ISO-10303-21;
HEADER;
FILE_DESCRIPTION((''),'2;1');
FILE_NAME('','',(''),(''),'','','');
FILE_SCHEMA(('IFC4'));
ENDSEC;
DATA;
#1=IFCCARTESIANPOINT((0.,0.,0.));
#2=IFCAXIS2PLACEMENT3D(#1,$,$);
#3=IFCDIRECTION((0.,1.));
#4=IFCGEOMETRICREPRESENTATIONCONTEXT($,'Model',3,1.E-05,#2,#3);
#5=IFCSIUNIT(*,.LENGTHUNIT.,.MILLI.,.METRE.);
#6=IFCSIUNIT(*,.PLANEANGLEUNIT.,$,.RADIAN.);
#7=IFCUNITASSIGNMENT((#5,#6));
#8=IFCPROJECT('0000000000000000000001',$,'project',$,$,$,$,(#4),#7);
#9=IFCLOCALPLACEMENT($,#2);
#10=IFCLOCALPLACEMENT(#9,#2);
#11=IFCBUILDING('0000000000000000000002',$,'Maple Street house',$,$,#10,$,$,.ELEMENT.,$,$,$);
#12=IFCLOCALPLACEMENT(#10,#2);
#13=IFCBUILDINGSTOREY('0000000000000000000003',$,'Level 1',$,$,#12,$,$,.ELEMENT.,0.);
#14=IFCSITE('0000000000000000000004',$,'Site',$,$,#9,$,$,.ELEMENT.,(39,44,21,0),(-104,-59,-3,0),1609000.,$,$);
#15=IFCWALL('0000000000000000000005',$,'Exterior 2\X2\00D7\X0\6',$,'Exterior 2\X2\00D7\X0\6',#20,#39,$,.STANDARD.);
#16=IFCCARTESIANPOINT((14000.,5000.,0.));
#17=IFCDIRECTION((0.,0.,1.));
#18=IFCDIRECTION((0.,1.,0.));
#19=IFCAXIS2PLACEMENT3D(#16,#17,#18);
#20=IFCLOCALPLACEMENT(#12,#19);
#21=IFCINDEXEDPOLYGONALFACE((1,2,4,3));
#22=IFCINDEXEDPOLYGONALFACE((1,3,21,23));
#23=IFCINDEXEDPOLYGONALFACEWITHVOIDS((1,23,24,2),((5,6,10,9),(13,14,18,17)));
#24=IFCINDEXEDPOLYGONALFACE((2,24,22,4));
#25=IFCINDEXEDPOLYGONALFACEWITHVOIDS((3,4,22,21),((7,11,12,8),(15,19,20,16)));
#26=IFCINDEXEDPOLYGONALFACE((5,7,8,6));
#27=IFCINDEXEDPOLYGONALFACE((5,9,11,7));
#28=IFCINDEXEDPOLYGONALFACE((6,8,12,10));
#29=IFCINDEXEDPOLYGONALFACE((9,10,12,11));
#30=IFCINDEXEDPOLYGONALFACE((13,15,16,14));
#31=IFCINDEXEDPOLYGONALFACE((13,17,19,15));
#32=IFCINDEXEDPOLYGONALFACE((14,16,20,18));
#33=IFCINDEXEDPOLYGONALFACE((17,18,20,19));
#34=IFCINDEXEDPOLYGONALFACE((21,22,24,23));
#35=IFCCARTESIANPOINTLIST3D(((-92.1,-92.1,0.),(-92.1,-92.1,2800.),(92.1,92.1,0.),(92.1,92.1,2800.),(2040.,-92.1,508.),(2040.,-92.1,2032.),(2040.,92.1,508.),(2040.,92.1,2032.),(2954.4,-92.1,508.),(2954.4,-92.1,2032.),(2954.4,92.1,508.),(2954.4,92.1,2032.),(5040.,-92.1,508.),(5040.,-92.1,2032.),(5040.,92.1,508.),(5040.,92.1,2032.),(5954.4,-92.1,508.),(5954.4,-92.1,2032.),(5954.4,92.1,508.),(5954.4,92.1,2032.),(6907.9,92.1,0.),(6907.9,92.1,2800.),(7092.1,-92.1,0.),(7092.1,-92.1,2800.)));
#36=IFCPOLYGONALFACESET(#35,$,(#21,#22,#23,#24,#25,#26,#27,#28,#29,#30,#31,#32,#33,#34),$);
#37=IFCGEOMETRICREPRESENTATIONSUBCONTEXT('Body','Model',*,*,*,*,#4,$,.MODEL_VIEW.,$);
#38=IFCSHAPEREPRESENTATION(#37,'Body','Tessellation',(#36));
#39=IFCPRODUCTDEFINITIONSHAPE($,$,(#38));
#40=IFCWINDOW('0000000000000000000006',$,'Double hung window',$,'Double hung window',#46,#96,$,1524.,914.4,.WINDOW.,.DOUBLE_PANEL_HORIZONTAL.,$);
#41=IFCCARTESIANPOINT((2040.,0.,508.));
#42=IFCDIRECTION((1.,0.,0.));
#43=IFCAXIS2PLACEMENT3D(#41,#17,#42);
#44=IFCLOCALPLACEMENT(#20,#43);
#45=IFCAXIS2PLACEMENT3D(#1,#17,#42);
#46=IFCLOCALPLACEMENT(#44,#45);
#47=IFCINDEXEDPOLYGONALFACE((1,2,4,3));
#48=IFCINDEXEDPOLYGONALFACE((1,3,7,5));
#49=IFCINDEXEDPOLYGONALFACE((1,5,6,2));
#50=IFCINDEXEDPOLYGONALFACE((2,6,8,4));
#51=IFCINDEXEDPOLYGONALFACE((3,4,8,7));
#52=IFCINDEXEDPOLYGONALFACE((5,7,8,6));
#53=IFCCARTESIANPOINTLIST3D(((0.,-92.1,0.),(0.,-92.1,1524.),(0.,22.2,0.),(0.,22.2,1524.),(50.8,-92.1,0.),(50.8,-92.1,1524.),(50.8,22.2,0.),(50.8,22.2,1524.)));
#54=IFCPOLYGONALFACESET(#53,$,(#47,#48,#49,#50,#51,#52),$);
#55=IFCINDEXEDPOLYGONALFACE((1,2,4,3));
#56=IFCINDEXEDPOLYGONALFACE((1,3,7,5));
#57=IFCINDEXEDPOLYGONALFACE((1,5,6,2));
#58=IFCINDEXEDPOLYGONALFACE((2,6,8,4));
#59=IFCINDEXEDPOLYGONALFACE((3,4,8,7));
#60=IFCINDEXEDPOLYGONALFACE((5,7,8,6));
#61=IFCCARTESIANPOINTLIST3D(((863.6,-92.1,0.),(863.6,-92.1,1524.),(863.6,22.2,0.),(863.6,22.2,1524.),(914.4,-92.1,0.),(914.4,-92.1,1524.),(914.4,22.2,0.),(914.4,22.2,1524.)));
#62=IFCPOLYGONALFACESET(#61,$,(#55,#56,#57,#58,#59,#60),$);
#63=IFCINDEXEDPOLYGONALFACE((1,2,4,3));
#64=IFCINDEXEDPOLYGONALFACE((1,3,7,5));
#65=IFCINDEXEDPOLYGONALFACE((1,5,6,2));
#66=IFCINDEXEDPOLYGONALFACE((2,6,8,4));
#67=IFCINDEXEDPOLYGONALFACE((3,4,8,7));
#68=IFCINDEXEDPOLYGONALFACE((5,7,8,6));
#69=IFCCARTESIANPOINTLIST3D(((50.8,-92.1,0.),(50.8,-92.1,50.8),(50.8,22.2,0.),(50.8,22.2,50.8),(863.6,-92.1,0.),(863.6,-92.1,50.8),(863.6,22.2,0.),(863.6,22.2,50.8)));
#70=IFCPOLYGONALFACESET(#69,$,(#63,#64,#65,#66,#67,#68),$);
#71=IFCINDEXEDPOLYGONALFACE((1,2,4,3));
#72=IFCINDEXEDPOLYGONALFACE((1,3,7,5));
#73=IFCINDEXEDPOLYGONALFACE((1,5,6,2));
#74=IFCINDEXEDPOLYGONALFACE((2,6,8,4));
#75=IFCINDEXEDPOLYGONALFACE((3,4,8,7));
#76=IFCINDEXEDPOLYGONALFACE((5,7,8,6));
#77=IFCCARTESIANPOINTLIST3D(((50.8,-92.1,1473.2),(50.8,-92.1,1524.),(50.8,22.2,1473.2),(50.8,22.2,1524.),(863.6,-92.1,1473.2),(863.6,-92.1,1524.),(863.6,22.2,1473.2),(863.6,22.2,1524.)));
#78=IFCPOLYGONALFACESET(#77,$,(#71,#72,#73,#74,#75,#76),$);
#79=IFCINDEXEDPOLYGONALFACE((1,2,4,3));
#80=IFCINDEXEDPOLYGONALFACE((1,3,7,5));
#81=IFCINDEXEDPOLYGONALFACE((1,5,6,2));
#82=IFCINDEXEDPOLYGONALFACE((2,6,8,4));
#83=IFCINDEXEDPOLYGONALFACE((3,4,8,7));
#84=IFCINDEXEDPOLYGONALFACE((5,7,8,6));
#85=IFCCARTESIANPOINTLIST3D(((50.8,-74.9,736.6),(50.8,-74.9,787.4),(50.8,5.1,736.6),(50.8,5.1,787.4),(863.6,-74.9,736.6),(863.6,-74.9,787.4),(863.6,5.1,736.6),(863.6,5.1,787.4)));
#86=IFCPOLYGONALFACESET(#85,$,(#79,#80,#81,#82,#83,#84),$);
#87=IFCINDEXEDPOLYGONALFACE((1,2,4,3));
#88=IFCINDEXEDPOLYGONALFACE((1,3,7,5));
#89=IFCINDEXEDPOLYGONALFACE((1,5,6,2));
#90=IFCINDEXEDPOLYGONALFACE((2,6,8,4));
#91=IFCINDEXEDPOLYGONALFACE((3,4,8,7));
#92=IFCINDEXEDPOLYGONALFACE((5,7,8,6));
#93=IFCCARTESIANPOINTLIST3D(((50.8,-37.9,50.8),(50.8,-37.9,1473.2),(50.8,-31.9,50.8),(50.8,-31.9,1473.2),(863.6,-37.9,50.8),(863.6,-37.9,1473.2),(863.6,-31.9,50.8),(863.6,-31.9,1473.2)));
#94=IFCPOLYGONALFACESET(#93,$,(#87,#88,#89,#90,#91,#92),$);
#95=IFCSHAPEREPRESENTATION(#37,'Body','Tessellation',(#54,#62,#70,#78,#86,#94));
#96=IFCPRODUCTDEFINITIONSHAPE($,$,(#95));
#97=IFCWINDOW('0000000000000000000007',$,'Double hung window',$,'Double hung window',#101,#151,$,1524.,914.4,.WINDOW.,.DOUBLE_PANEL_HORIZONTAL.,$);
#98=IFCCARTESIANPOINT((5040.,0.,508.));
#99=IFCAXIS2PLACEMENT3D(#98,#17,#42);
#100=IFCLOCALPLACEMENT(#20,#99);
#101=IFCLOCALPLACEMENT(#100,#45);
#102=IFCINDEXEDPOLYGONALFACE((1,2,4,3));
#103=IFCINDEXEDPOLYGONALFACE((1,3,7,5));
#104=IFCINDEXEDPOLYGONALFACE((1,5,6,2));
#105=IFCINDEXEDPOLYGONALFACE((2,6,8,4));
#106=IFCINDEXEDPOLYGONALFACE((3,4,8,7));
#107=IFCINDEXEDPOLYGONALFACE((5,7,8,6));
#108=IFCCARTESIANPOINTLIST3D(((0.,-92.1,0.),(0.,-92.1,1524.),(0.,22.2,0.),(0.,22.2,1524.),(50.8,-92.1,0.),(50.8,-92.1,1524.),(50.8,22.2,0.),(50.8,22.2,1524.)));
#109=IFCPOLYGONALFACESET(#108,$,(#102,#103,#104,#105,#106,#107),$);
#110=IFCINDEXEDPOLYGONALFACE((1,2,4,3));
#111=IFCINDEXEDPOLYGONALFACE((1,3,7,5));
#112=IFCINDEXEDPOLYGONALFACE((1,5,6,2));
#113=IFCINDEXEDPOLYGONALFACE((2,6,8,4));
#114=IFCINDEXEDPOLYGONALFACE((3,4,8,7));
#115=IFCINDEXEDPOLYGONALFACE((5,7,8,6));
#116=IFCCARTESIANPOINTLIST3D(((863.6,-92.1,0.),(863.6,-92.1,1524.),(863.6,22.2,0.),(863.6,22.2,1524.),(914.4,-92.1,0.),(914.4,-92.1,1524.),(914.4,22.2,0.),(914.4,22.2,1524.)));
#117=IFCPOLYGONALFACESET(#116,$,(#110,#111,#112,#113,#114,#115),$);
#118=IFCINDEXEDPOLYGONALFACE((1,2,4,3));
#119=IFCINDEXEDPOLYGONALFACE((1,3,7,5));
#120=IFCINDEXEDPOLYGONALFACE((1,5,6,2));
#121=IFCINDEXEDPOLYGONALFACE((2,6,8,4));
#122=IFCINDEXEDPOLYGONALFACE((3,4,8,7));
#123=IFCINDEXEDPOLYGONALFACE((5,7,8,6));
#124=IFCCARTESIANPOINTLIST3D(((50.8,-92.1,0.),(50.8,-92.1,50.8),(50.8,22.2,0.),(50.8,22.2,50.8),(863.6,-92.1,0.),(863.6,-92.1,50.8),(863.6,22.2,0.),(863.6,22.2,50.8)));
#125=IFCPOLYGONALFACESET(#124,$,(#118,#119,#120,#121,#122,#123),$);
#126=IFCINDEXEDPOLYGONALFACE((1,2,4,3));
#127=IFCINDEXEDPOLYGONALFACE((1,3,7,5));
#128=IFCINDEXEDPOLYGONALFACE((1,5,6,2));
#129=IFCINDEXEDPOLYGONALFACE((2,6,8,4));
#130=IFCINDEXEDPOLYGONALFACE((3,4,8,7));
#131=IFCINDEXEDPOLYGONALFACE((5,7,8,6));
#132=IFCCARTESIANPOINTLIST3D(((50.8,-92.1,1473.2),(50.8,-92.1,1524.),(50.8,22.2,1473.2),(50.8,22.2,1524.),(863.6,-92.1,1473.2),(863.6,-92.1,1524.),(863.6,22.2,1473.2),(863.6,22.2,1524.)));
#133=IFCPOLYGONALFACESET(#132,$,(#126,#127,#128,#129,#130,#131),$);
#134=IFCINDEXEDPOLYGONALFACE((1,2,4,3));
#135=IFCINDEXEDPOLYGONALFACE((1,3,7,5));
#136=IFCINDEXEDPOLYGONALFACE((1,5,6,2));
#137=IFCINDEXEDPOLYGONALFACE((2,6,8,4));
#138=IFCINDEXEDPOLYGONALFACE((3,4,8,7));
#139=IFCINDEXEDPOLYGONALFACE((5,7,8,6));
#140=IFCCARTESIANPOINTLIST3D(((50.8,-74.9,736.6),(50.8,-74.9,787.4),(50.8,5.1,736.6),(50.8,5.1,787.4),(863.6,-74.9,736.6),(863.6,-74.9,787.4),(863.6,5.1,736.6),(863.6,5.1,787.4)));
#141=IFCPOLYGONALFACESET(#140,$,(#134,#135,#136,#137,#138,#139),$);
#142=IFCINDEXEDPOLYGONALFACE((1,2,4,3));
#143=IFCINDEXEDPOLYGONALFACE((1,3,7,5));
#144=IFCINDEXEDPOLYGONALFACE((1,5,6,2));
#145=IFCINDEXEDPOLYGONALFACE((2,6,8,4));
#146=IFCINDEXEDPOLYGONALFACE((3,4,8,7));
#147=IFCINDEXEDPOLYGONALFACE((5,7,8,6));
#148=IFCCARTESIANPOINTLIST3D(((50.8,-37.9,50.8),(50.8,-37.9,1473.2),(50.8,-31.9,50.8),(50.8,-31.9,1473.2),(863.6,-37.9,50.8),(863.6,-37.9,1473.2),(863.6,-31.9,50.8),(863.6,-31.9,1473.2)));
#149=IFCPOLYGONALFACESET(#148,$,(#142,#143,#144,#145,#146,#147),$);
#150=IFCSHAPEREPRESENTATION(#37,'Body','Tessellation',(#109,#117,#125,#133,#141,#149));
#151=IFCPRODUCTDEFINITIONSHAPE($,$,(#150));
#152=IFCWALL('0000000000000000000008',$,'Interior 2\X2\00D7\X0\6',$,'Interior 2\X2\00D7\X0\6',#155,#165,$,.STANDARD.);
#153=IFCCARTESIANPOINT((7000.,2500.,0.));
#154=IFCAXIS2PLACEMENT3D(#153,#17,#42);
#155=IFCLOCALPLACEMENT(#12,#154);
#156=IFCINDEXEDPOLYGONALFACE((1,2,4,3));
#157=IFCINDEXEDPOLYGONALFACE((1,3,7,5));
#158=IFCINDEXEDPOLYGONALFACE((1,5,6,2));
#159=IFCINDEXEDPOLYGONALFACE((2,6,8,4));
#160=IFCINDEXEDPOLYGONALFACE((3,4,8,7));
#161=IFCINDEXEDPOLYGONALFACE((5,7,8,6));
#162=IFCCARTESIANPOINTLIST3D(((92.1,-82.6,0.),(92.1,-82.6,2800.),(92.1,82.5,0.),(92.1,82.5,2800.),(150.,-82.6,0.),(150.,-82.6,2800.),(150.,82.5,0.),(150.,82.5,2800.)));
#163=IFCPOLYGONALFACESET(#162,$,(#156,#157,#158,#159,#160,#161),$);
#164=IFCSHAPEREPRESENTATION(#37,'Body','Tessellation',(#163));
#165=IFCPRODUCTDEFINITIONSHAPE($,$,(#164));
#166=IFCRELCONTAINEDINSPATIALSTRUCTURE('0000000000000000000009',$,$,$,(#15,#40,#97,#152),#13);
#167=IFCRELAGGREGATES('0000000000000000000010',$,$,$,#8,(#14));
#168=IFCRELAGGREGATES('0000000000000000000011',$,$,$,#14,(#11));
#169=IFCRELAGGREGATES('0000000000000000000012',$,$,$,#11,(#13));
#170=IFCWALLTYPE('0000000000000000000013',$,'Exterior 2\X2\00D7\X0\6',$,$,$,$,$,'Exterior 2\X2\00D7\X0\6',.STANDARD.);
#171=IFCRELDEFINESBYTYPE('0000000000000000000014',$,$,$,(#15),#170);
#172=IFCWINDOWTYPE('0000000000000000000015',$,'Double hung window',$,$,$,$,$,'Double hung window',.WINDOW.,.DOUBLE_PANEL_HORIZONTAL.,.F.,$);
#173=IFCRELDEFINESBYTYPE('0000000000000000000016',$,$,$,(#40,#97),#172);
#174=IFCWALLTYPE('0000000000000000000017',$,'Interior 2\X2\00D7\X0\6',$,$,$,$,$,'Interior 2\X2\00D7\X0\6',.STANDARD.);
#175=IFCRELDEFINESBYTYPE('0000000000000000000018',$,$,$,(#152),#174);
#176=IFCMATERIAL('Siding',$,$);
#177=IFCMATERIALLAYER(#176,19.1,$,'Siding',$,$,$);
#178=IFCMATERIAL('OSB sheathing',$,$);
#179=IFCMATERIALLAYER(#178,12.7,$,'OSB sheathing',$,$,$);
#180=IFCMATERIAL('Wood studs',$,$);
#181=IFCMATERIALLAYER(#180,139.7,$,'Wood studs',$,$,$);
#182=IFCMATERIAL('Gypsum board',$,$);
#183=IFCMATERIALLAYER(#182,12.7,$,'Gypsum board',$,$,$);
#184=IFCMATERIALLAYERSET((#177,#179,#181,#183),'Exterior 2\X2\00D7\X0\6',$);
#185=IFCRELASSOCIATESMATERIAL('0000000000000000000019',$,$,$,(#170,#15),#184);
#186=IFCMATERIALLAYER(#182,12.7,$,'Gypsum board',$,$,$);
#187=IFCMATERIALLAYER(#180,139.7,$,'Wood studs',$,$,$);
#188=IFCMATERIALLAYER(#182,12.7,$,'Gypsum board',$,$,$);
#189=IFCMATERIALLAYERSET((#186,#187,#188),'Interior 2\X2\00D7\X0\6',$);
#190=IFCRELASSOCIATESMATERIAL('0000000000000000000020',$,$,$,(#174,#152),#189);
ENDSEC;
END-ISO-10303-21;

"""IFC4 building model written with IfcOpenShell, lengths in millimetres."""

from ifc_helpers import new_model, si_unit, direction, frame, origin, origin_with_axes, place, context, subcontext, project, spatial, polyline, outline, extrude, material, layer, layer_set, layer_usage, type_object, element, fill, save


model = new_model("IFC4")

# Units and contexts
model_context = context("Model", 3, precision=1e-05, world=origin(), true_north=direction((0.0, 1.0)))
body_context = subcontext(model_context, "Body", "Model", "MODEL_VIEW")
ifc_project = project(units=[si_unit("LENGTHUNIT", "METRE", prefix="MILLI"), si_unit("PLANEANGLEUNIT", "RADIAN")], contexts=[model_context])

# Site, building, storey
site_placement = place(None, origin())
site = spatial("IfcSite", under=ifc_project, at=site_placement, Name="Site", CompositionType="ELEMENT", RefLatitude=(39, 44, 21, 0), RefLongitude=(-104, -59, -3, 0), RefElevation=1609000.0)
building_placement = place(site_placement, origin())
building = spatial("IfcBuilding", under=site, at=building_placement, Name="Maple Street house", CompositionType="ELEMENT")
storey_placement = place(building_placement, origin())
storey = spatial("IfcBuildingStorey", under=building, at=storey_placement, Name="Level 1", CompositionType="ELEMENT", Elevation=0.0)

# Shared definitions
ifc_material_1 = material(Name="Siding")
ifc_layer_1 = layer(ifc_material_1, 19.1, Name="Siding")
ifc_material_2 = material(Name="OSB sheathing")
ifc_layer_2 = layer(ifc_material_2, 12.7, Name="OSB sheathing")
ifc_material_3 = material(Name="Wood studs")
ifc_layer_3 = layer(ifc_material_3, 139.7, Name="Wood studs")
ifc_material_4 = material(Name="Gypsum board")
ifc_layer_4 = layer(ifc_material_4, 12.7, Name="Gypsum board")
ifc_layer_set_1 = layer_set([ifc_layer_1, ifc_layer_2, ifc_layer_3, ifc_layer_4], Name="Exterior 2×6")
wall_type_1 = type_object("IfcWallType", Name="Exterior 2×6", ElementType="Exterior 2×6", PredefinedType="STANDARD", material=ifc_layer_set_1)

# Wall, openings, windows
ifc_layer_usage_1 = layer_usage(ifc_layer_set_1, "AXIS2", "POSITIVE", -92.1)
wall_1_placement = place(storey_placement, frame((14000.0, 5000.0, 0.0), z_axis=(0.0, 0.0, 1.0), x_axis=(0.0, 1.0, 0.0)))
wall_1 = element("IfcWall", 1, at=wall_1_placement, inside=storey, type_object=wall_type_1, material=ifc_layer_usage_1, Name="Exterior 2×6", ObjectType="Exterior 2×6", PredefinedType="STANDARD", context=body_context, shape_type="SweptSolid", body=[
    extrude(outline(polyline([(-92.1, -92.1), (7092.1, -92.1), (6907.9, 92.1), (92.1, 92.1), (-92.1, -92.1)])), origin(), (0.0, 0.0, 1.0), 2800.0),
])
opening_1_placement = place(wall_1_placement, frame((2040.0, 0.0, 508.0), z_axis=(0.0, 0.0, 1.0), x_axis=(1.0, 0.0, 0.0)))
opening_1 = element("IfcOpeningElement", 2, at=opening_1_placement, cuts=wall_1, PredefinedType="OPENING", context=body_context, shape_type="SweptSolid", body=[
    extrude(outline(polyline([(0.0, -102.1), (914.4, -102.1), (914.4, 102.1), (0.0, 102.1), (0.0, -102.1)])), origin(), (0.0, 0.0, 1.0), 1524.0),
])
opening_2_placement = place(wall_1_placement, frame((5040.0, 0.0, 508.0), z_axis=(0.0, 0.0, 1.0), x_axis=(1.0, 0.0, 0.0)))
opening_2 = element("IfcOpeningElement", 3, at=opening_2_placement, cuts=wall_1, PredefinedType="OPENING", context=body_context, shape_type="SweptSolid", body=[
    extrude(outline(polyline([(0.0, -102.1), (914.4, -102.1), (914.4, 102.1), (0.0, 102.1), (0.0, -102.1)])), origin(), (0.0, 0.0, 1.0), 1524.0),
])
window_type_1 = type_object("IfcWindowType", Name="Double hung window", ElementType="Double hung window", ParameterTakesPrecedence=False, PartitioningType="DOUBLE_PANEL_HORIZONTAL", PredefinedType="WINDOW")
window_1_placement = place(opening_1_placement, origin_with_axes())
window_1 = element("IfcWindow", 4, at=window_1_placement, inside=storey, type_object=window_type_1, Name="Double hung window", ObjectType="Double hung window", OverallHeight=1524.0, OverallWidth=914.4, PartitioningType="DOUBLE_PANEL_HORIZONTAL", PredefinedType="WINDOW", context=body_context, shape_type="SweptSolid", body=[
    extrude(outline(polyline([(0.0, -92.1), (50.8, -92.1), (50.8, 22.2), (0.0, 22.2), (0.0, -92.1)])), origin(), (0.0, 0.0, 1.0), 1524.0),
    extrude(outline(polyline([(863.6, -92.1), (914.4, -92.1), (914.4, 22.2), (863.6, 22.2), (863.6, -92.1)])), origin(), (0.0, 0.0, 1.0), 1524.0),
    extrude(outline(polyline([(50.8, -92.1), (863.6, -92.1), (863.6, 22.2), (50.8, 22.2), (50.8, -92.1)])), origin(), (0.0, 0.0, 1.0), 50.8),
    extrude(outline(polyline([(50.8, -92.1), (863.6, -92.1), (863.6, 22.2), (50.8, 22.2), (50.8, -92.1)])), frame((0.0, 0.0, 1473.2)), (0.0, 0.0, 1.0), 50.8),
    extrude(outline(polyline([(50.8, -74.9), (863.6, -74.9), (863.6, 5.1), (50.8, 5.1), (50.8, -74.9)])), frame((0.0, 0.0, 736.6)), (0.0, 0.0, 1.0), 50.8),
    extrude(outline(polyline([(50.8, -37.9), (863.6, -37.9), (863.6, -31.9), (50.8, -31.9), (50.8, -37.9)])), frame((0.0, 0.0, 50.8)), (0.0, 0.0, 1.0), 1422.4),
])
fill(opening_1, window_1)
window_2_placement = place(opening_2_placement, origin_with_axes())
window_2 = element("IfcWindow", 5, at=window_2_placement, inside=storey, type_object=window_type_1, Name="Double hung window", ObjectType="Double hung window", OverallHeight=1524.0, OverallWidth=914.4, PartitioningType="DOUBLE_PANEL_HORIZONTAL", PredefinedType="WINDOW", context=body_context, shape_type="SweptSolid", body=[
    extrude(outline(polyline([(0.0, -92.1), (50.8, -92.1), (50.8, 22.2), (0.0, 22.2), (0.0, -92.1)])), origin(), (0.0, 0.0, 1.0), 1524.0),
    extrude(outline(polyline([(863.6, -92.1), (914.4, -92.1), (914.4, 22.2), (863.6, 22.2), (863.6, -92.1)])), origin(), (0.0, 0.0, 1.0), 1524.0),
    extrude(outline(polyline([(50.8, -92.1), (863.6, -92.1), (863.6, 22.2), (50.8, 22.2), (50.8, -92.1)])), origin(), (0.0, 0.0, 1.0), 50.8),
    extrude(outline(polyline([(50.8, -92.1), (863.6, -92.1), (863.6, 22.2), (50.8, 22.2), (50.8, -92.1)])), frame((0.0, 0.0, 1473.2)), (0.0, 0.0, 1.0), 50.8),
    extrude(outline(polyline([(50.8, -74.9), (863.6, -74.9), (863.6, 5.1), (50.8, 5.1), (50.8, -74.9)])), frame((0.0, 0.0, 736.6)), (0.0, 0.0, 1.0), 50.8),
    extrude(outline(polyline([(50.8, -37.9), (863.6, -37.9), (863.6, -31.9), (50.8, -31.9), (50.8, -37.9)])), frame((0.0, 0.0, 50.8)), (0.0, 0.0, 1.0), 1422.4),
])
fill(opening_2, window_2)

# Wall
ifc_layer_5 = layer(ifc_material_4, 12.7, Name="Gypsum board")
ifc_layer_6 = layer(ifc_material_3, 139.7, Name="Wood studs")
ifc_layer_7 = layer(ifc_material_4, 12.7, Name="Gypsum board")
ifc_layer_set_2 = layer_set([ifc_layer_5, ifc_layer_6, ifc_layer_7], Name="Interior 2×6")
ifc_layer_usage_2 = layer_usage(ifc_layer_set_2, "AXIS2", "NEGATIVE", 82.5)
wall_type_2 = type_object("IfcWallType", Name="Interior 2×6", ElementType="Interior 2×6", PredefinedType="STANDARD", material=ifc_layer_set_2)
wall_2_placement = place(storey_placement, frame((7000.0, 2500.0, 0.0), z_axis=(0.0, 0.0, 1.0), x_axis=(1.0, 0.0, 0.0)))
element("IfcWall", 6, at=wall_2_placement, inside=storey, type_object=wall_type_2, material=ifc_layer_usage_2, Name="Interior 2×6", ObjectType="Interior 2×6", PredefinedType="STANDARD", context=body_context, shape_type="SweptSolid", body=[
    extrude(outline(polyline([(92.1, -82.5), (150.0, -82.5), (150.0, 82.5), (92.1, 82.5), (92.1, -82.5)])), origin(), (0.0, 0.0, 1.0), 2800.0),
])

save(model, "model.ifc")
